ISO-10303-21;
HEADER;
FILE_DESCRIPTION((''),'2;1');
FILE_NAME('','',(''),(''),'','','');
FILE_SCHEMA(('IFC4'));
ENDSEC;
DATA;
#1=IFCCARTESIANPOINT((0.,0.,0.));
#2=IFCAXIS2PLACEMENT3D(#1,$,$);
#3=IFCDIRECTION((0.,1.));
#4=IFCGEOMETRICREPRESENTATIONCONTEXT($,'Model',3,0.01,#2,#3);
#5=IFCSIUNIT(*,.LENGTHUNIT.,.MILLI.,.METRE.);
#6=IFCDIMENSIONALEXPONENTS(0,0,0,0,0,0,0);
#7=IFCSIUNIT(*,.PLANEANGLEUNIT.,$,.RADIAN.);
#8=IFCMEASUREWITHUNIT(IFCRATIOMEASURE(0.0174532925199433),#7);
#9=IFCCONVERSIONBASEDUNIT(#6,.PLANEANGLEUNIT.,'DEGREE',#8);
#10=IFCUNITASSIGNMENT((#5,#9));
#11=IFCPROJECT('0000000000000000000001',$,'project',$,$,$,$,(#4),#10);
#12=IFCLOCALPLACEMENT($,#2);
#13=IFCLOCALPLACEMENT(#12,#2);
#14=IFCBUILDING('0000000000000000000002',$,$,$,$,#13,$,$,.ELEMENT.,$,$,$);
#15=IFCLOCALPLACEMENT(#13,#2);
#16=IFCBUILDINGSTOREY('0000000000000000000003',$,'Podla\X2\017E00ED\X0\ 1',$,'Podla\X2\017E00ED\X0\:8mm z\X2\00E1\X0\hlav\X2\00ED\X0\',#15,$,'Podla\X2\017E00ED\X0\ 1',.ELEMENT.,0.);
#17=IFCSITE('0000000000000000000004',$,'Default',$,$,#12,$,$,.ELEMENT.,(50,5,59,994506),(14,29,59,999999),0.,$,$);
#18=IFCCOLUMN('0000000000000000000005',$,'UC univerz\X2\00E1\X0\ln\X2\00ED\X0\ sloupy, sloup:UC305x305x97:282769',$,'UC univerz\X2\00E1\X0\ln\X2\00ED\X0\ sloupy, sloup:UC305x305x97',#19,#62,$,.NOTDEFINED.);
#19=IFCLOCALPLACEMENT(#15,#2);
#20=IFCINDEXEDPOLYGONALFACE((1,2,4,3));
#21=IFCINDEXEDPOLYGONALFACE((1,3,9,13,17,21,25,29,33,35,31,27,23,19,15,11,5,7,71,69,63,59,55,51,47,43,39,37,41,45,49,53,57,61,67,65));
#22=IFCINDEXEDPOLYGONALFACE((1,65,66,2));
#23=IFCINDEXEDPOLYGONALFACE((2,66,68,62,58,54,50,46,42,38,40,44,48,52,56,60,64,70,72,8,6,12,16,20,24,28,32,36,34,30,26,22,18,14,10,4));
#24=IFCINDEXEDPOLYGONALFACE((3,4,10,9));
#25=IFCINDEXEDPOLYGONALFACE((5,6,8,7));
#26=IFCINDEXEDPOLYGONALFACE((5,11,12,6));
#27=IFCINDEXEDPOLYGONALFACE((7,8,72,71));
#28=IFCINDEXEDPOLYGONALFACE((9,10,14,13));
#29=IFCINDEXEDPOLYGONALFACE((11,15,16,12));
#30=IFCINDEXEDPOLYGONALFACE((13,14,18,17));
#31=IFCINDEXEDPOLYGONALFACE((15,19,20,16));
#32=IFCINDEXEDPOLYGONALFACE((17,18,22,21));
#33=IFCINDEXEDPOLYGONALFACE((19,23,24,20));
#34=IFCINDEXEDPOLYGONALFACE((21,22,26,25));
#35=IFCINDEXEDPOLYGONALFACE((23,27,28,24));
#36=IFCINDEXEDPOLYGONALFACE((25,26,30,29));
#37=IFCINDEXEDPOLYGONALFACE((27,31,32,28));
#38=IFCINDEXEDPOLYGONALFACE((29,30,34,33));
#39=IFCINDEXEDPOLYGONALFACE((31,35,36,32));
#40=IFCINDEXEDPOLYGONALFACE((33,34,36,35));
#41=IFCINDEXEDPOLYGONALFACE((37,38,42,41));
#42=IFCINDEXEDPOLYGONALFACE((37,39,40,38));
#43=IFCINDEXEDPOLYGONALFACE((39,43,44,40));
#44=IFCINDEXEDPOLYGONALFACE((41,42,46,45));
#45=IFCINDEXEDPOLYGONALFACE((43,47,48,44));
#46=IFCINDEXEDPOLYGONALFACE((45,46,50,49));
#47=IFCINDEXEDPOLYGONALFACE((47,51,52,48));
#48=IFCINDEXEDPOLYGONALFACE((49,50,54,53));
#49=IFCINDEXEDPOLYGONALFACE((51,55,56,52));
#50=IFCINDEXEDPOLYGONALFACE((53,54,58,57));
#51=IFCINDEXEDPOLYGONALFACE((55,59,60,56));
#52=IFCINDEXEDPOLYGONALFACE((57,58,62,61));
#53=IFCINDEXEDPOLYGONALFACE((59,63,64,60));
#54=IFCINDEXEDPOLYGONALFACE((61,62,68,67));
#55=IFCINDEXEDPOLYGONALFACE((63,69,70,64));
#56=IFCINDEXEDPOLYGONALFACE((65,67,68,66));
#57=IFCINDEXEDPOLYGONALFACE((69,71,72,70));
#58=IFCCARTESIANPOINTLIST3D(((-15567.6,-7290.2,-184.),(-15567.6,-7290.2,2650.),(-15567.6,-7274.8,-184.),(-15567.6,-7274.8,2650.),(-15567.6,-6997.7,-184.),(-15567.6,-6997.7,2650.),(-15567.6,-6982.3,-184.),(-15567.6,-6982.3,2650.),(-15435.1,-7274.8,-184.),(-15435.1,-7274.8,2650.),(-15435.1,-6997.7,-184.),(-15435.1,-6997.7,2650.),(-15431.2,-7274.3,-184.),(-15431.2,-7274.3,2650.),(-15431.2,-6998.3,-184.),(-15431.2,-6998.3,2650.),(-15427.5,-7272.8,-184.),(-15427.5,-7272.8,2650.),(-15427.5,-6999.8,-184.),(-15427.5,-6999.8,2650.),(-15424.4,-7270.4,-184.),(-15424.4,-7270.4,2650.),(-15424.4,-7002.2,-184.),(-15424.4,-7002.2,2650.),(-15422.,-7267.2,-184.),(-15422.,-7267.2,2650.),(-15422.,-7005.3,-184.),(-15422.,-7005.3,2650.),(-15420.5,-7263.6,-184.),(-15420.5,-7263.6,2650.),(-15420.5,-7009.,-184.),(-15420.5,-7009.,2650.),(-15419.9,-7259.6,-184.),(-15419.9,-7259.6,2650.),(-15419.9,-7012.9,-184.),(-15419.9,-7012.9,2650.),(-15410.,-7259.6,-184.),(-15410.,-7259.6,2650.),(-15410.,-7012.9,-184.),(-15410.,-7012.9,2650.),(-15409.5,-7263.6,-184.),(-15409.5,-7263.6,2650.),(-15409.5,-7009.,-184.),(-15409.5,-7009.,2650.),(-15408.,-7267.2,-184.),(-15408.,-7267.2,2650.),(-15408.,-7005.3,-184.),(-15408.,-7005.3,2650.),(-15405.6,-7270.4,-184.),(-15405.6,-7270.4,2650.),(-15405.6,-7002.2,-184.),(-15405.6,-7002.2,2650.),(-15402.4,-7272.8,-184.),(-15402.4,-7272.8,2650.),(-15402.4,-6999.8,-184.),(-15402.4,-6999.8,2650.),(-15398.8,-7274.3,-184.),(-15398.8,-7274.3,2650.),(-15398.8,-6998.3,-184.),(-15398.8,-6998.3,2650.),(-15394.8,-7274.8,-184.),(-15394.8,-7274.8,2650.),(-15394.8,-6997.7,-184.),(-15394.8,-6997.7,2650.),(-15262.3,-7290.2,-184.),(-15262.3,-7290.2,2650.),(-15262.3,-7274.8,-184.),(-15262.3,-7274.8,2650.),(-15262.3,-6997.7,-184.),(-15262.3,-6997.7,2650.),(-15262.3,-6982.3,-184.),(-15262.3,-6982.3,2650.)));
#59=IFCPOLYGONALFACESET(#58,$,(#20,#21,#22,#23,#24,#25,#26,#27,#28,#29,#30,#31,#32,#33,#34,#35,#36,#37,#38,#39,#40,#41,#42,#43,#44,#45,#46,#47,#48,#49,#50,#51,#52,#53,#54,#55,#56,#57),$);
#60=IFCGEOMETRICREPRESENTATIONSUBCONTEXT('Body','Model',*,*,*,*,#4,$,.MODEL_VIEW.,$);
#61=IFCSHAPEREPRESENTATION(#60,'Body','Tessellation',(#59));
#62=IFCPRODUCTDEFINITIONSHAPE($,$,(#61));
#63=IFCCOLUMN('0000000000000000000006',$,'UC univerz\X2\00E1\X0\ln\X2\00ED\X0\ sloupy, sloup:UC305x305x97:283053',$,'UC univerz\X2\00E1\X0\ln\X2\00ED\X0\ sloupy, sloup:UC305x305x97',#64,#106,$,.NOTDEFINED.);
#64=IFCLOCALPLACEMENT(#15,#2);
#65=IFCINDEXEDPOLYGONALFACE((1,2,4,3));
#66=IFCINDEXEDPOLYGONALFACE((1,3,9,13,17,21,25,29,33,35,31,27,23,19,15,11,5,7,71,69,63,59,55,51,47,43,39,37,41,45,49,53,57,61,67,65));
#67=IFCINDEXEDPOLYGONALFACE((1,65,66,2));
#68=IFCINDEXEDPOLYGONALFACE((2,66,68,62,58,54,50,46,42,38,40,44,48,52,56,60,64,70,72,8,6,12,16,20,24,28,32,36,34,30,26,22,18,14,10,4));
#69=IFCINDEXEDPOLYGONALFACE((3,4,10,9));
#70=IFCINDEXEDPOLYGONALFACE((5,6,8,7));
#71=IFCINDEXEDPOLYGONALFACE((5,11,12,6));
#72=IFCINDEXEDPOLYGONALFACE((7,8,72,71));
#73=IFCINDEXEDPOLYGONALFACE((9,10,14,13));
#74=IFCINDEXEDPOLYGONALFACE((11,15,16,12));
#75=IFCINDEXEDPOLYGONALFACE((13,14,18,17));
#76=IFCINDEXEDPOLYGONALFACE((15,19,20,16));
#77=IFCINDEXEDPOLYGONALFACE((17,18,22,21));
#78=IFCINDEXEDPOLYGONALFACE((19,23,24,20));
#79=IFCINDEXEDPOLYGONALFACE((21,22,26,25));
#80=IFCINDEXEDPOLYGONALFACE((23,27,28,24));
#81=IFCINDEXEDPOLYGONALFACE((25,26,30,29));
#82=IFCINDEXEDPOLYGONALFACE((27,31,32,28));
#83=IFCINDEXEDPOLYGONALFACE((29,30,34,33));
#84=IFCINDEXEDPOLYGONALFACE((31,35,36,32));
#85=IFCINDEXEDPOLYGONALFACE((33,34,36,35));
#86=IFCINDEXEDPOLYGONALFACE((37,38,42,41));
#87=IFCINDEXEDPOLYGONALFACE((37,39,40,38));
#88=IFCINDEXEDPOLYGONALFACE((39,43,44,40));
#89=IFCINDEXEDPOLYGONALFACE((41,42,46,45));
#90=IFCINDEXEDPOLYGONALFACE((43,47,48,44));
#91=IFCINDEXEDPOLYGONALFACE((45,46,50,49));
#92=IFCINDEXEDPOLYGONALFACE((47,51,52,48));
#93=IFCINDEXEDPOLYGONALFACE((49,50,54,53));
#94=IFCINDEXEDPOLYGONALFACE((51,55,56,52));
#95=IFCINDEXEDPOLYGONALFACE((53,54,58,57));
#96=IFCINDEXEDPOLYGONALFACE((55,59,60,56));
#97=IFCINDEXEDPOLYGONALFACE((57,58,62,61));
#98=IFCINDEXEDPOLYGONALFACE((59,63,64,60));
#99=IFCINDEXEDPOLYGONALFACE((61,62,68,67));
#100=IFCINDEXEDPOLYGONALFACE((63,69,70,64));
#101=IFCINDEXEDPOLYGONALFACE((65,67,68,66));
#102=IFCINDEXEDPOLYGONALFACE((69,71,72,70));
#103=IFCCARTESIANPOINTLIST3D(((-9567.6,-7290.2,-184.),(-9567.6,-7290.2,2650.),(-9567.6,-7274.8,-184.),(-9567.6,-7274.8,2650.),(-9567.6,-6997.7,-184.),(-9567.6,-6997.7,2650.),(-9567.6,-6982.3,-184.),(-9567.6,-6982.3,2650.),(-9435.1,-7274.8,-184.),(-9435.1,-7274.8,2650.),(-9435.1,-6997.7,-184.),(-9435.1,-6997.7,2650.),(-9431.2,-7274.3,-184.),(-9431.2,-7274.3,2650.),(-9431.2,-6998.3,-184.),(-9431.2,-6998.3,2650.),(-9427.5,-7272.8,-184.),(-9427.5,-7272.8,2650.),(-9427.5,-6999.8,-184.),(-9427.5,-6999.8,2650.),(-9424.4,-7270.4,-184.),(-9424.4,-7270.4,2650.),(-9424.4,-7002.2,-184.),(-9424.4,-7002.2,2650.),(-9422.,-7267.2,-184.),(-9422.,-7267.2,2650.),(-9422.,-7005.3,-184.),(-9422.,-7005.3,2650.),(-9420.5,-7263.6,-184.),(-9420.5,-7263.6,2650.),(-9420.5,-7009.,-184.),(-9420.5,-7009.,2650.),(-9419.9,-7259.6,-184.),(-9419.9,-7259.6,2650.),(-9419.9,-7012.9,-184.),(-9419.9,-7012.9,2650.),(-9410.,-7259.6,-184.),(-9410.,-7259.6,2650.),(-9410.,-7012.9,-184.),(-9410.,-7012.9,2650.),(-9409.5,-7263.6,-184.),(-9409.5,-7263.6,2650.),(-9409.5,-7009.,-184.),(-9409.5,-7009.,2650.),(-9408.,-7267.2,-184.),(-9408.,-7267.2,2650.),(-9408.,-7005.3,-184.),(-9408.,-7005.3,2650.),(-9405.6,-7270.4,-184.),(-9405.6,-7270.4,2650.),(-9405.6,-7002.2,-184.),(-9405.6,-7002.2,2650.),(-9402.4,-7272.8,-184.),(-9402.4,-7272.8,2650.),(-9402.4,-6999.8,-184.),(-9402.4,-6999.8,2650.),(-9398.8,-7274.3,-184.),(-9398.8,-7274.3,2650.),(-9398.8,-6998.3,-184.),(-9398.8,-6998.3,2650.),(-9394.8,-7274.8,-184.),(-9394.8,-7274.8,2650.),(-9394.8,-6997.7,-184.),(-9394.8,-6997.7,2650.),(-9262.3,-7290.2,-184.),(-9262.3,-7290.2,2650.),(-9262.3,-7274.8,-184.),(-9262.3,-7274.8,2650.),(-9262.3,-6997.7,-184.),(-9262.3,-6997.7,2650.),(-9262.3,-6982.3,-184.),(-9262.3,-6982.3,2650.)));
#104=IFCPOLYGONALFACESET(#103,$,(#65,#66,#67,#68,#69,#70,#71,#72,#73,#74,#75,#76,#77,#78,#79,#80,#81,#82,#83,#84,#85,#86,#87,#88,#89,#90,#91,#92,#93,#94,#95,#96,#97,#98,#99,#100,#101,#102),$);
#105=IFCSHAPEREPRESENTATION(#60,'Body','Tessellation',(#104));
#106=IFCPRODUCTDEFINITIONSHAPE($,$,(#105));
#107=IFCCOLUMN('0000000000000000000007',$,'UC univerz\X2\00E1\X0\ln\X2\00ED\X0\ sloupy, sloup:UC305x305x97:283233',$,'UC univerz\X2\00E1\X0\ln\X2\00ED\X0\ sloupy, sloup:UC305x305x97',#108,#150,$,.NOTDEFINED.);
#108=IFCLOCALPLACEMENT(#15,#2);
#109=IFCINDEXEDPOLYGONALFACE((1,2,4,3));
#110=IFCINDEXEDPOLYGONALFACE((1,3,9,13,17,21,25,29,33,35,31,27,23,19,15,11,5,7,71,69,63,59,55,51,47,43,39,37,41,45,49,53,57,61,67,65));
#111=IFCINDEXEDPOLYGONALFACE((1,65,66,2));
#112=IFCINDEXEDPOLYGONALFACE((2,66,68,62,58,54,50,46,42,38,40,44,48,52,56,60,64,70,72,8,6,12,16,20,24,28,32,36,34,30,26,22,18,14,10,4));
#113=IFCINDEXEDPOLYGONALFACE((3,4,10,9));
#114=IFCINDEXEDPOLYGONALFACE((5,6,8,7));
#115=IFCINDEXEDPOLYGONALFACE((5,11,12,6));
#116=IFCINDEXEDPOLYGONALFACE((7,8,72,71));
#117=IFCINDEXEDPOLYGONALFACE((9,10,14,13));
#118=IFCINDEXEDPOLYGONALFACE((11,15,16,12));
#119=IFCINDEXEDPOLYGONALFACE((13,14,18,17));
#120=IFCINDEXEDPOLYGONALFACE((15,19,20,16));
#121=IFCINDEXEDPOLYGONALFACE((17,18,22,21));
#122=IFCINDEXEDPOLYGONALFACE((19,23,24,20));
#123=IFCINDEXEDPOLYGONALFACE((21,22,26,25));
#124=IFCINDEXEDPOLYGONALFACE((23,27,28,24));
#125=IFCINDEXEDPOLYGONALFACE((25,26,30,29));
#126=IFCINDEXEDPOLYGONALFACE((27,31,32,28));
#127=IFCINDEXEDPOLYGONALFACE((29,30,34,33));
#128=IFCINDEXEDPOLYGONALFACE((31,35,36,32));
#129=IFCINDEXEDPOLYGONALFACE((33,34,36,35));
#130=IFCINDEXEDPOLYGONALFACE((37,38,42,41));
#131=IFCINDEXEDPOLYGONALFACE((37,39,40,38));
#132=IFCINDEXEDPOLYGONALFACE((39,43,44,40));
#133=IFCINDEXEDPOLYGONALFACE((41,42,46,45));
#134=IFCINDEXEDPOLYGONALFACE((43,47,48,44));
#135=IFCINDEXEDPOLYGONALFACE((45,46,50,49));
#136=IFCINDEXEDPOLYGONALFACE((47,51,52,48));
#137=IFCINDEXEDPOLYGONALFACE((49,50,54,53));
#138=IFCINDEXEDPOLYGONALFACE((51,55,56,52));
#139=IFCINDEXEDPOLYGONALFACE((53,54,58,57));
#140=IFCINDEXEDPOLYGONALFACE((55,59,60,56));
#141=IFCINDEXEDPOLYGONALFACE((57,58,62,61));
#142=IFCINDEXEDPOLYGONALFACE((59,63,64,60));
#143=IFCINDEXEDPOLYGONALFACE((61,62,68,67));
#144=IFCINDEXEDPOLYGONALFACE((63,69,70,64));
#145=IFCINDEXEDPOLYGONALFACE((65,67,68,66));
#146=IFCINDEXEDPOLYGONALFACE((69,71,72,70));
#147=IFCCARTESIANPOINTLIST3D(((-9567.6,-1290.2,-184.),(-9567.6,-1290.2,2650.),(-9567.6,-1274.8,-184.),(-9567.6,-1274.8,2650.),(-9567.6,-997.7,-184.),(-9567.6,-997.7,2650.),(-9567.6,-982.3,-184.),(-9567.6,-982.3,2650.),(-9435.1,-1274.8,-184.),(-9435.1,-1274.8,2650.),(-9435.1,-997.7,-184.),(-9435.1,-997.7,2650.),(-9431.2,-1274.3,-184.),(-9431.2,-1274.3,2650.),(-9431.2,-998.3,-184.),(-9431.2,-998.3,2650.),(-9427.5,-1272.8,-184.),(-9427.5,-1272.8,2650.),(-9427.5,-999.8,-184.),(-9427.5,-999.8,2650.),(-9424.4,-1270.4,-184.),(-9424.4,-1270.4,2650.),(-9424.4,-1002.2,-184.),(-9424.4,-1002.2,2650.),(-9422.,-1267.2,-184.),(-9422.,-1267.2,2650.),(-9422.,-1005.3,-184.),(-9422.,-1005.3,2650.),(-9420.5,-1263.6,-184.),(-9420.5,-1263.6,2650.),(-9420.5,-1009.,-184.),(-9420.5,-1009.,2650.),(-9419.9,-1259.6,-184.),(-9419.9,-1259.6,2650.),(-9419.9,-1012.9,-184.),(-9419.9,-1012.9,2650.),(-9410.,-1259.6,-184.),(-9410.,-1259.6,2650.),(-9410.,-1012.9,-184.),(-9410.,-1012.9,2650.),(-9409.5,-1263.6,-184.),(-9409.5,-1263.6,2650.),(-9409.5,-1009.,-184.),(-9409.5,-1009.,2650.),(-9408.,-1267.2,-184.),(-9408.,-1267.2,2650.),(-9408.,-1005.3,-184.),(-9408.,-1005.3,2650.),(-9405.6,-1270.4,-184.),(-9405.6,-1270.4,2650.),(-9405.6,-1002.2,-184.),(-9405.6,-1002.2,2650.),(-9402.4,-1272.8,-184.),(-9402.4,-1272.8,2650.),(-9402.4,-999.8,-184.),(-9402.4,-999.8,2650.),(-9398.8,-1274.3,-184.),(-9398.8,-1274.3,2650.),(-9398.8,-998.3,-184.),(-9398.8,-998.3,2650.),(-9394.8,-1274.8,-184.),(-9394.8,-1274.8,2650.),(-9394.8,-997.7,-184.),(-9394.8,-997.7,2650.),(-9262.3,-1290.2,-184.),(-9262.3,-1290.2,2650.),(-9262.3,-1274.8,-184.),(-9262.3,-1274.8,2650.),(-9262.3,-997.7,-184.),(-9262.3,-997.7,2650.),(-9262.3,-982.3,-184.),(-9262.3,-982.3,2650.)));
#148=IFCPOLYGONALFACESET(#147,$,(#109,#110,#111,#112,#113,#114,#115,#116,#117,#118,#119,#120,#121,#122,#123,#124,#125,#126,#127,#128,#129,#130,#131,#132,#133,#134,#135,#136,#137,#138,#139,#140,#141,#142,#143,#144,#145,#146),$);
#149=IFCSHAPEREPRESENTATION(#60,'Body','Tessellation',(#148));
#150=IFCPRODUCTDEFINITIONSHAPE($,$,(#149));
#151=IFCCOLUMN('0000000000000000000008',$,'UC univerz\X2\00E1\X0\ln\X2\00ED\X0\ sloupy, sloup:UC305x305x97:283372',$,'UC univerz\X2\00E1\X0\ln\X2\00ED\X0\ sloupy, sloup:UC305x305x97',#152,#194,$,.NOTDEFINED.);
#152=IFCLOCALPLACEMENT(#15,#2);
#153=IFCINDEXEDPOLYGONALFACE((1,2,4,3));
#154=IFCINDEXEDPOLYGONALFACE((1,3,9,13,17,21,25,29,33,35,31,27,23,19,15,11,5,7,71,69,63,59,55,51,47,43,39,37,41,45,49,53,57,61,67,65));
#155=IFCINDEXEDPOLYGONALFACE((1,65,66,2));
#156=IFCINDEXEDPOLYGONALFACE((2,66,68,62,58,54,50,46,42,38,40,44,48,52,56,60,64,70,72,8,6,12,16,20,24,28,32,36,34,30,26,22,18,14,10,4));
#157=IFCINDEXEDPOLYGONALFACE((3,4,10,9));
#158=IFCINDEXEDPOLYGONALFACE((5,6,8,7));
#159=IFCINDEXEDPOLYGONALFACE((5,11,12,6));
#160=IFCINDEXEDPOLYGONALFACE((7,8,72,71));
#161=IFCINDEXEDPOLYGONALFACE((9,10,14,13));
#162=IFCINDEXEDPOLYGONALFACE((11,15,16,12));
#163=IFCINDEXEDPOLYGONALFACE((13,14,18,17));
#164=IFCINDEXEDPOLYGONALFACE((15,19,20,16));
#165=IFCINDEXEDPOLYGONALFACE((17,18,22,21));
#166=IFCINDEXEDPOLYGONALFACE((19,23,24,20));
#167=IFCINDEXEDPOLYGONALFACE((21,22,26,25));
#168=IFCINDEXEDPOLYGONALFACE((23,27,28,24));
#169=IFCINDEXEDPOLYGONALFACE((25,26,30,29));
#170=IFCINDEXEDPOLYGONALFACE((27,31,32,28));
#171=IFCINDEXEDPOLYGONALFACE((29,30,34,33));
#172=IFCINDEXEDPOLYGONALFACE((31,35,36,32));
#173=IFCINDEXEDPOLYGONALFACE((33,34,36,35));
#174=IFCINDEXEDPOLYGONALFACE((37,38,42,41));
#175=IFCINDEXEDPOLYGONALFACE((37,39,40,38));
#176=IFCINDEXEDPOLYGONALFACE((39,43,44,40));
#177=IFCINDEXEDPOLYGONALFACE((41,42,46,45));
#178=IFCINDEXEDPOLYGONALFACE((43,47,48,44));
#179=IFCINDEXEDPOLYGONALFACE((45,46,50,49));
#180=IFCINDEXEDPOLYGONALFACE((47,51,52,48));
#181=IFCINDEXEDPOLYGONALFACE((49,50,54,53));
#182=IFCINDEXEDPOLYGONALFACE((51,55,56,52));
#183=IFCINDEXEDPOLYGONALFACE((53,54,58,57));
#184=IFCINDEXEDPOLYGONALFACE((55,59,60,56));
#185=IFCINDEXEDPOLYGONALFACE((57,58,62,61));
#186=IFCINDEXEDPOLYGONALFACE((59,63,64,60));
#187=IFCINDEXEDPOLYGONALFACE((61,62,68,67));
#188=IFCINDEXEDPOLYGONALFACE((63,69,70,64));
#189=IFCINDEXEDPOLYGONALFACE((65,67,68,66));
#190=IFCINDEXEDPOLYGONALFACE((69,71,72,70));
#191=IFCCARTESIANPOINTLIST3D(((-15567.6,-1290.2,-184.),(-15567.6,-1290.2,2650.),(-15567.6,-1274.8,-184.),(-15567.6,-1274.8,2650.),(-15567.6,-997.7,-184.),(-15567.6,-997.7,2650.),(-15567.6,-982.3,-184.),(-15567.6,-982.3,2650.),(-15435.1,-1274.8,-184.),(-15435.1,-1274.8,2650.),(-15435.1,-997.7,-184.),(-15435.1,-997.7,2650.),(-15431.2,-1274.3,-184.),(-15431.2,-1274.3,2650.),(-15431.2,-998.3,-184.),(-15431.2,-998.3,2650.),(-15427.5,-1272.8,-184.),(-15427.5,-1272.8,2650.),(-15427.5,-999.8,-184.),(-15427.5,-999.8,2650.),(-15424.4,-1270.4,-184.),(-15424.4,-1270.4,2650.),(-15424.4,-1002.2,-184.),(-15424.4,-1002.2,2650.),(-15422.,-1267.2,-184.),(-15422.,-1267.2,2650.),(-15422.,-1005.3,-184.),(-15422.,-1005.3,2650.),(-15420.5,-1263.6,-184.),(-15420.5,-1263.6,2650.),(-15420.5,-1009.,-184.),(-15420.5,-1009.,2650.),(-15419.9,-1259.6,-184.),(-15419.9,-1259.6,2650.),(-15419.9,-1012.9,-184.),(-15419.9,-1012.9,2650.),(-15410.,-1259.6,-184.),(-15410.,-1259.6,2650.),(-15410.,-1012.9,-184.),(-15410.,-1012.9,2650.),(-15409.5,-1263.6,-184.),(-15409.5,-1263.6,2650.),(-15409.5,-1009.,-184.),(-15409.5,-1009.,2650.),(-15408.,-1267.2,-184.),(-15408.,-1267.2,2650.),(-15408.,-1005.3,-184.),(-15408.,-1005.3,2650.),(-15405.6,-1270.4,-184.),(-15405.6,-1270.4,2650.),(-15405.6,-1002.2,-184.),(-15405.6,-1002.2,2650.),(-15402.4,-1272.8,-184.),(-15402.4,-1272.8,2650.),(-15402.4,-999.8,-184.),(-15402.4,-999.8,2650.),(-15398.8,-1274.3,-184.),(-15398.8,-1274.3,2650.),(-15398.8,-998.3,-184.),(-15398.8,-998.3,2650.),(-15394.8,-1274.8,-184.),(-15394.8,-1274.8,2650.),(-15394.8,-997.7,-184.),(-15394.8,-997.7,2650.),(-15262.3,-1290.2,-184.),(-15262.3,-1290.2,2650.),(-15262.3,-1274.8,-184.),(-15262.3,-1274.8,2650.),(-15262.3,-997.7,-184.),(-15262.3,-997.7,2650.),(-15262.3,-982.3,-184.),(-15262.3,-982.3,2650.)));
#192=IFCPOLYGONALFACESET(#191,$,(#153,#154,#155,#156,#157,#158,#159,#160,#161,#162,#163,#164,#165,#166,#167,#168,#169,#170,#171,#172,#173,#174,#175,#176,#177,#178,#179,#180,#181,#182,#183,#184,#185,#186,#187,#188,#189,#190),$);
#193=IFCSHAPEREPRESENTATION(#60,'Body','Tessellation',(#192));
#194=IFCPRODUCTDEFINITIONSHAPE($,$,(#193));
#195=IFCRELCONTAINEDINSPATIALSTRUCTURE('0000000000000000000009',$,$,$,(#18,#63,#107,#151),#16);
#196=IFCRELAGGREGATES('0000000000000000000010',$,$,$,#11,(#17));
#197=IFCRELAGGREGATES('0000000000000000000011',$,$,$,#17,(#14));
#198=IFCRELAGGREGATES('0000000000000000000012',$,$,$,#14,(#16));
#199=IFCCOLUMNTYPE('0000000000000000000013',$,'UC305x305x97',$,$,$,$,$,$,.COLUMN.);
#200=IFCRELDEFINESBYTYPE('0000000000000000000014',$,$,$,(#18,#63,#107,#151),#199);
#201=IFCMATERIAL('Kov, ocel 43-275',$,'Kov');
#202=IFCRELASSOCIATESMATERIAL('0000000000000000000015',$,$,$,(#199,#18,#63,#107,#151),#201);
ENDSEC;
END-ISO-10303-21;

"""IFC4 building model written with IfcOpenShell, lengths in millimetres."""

from ifc_helpers import new_model, entity, si_unit, converted_unit, direction, frame, frame_2d, origin, place, context, subcontext, project, spatial, i_section, extrude, source, transform, mapped, material, material_profile, profile_set, profile_usage, type_object, type_shapes, element, save


model = new_model("IFC4")

# Units and contexts
model_context = context("Model", 3, precision=0.01, world=origin(), true_north=direction((0.0, 1.0)))
body_context = subcontext(model_context, "Body", "Model", "MODEL_VIEW")
ifc_project = project(units=[si_unit("LENGTHUNIT", "METRE", prefix="MILLI"), converted_unit("PLANEANGLEUNIT", "DEGREE", entity("IfcRatioMeasure", 0.0174532925199433), si_unit("PLANEANGLEUNIT", "RADIAN"), dimensions=[0, 0, 0, 0, 0, 0, 0])], contexts=[model_context])

# Site, building, storey
site_placement = place(None, origin())
site = spatial("IfcSite", under=ifc_project, at=site_placement, Name="Default", CompositionType="ELEMENT", RefLatitude=(50, 5, 59, 994506), RefLongitude=(14, 29, 59, 999999), RefElevation=0.0)
building_placement = place(site_placement, origin())
building = spatial("IfcBuilding", under=site, at=building_placement, CompositionType="ELEMENT")
storey_placement = place(building_placement, origin())
storey = spatial("IfcBuildingStorey", under=building, at=storey_placement, Name="Podlaží 1", ObjectType="Podlaží:8mm záhlaví", LongName="Podlaží 1", CompositionType="ELEMENT", Elevation=0.0)

# Columns
ifc_material_1 = material(Name="Kov, ocel 43-275", Category="Kov")
ifc_material_profile = material_profile(ifc_material_1, i_section(OverallWidth=305.3, OverallDepth=307.9, WebThickness=9.9, FlangeThickness=15.4, FilletRadius=15.2, at=frame_2d((0.0, 0.0), x_axis=(0.0, 1.0))), Name="UC305x305x97")
ifc_profile_set = profile_set([ifc_material_profile], Name="UC305x305x97")
ifc_profile_usage_1 = profile_usage(ifc_profile_set)
column_type = type_object("IfcColumnType", Name="UC305x305x97", PredefinedType="COLUMN", material=ifc_profile_set)
shared_shape_1 = source(origin(), body_context, "Body", "SweptSolid", [
    extrude(i_section(OverallWidth=305.3, OverallDepth=307.9, WebThickness=9.9, FlangeThickness=15.4, FilletRadius=15.2, at=frame_2d((0.0, 0.0), x_axis=(0.0, 1.0))), frame((0.0, 0.0, -184.0), z_axis=(0.0, 0.0, 1.0), x_axis=(0.0, -1.0, 0.0)), (0.0, 0.0, 1.0), 2834.0),
])
type_shapes(column_type, [shared_shape_1])
column_1_placement = place(storey_placement, frame((-15415.0, -7136.3, 0.0)))
element("IfcColumn", 1, at=column_1_placement, inside=storey, type_object=column_type, material=ifc_profile_usage_1, Name="UC univerzální sloupy, sloup:UC305x305x97:282769", ObjectType="UC univerzální sloupy, sloup:UC305x305x97", PredefinedType="NOTDEFINED", context=body_context, shape_type="MappedRepresentation", body=[
    mapped(shared_shape_1, transform((0.0, 0.0, 0.0), scale=1.0)),
])
ifc_profile_usage_2 = profile_usage(ifc_profile_set)
column_2_placement = place(storey_placement, frame((-9415.0, -7136.3, 0.0)))
element("IfcColumn", 2, at=column_2_placement, inside=storey, type_object=column_type, material=ifc_profile_usage_2, Name="UC univerzální sloupy, sloup:UC305x305x97:283053", ObjectType="UC univerzální sloupy, sloup:UC305x305x97", PredefinedType="NOTDEFINED", context=body_context, shape_type="MappedRepresentation", body=[
    mapped(shared_shape_1, transform((0.0, 0.0, 0.0), scale=1.0)),
])
ifc_profile_usage_3 = profile_usage(ifc_profile_set)
column_3_placement = place(storey_placement, frame((-9415.0, -1136.3, 0.0)))
element("IfcColumn", 3, at=column_3_placement, inside=storey, type_object=column_type, material=ifc_profile_usage_3, Name="UC univerzální sloupy, sloup:UC305x305x97:283233", ObjectType="UC univerzální sloupy, sloup:UC305x305x97", PredefinedType="NOTDEFINED", context=body_context, shape_type="MappedRepresentation", body=[
    mapped(shared_shape_1, transform((0.0, 0.0, 0.0), scale=1.0)),
])
ifc_profile_usage_4 = profile_usage(ifc_profile_set)
column_4_placement = place(storey_placement, frame((-15415.0, -1136.3, 0.0)))
element("IfcColumn", 4, at=column_4_placement, inside=storey, type_object=column_type, material=ifc_profile_usage_4, Name="UC univerzální sloupy, sloup:UC305x305x97:283372", ObjectType="UC univerzální sloupy, sloup:UC305x305x97", PredefinedType="NOTDEFINED", context=body_context, shape_type="MappedRepresentation", body=[
    mapped(shared_shape_1, transform((0.0, 0.0, 0.0), scale=1.0)),
])

save(model, "model.ifc")
